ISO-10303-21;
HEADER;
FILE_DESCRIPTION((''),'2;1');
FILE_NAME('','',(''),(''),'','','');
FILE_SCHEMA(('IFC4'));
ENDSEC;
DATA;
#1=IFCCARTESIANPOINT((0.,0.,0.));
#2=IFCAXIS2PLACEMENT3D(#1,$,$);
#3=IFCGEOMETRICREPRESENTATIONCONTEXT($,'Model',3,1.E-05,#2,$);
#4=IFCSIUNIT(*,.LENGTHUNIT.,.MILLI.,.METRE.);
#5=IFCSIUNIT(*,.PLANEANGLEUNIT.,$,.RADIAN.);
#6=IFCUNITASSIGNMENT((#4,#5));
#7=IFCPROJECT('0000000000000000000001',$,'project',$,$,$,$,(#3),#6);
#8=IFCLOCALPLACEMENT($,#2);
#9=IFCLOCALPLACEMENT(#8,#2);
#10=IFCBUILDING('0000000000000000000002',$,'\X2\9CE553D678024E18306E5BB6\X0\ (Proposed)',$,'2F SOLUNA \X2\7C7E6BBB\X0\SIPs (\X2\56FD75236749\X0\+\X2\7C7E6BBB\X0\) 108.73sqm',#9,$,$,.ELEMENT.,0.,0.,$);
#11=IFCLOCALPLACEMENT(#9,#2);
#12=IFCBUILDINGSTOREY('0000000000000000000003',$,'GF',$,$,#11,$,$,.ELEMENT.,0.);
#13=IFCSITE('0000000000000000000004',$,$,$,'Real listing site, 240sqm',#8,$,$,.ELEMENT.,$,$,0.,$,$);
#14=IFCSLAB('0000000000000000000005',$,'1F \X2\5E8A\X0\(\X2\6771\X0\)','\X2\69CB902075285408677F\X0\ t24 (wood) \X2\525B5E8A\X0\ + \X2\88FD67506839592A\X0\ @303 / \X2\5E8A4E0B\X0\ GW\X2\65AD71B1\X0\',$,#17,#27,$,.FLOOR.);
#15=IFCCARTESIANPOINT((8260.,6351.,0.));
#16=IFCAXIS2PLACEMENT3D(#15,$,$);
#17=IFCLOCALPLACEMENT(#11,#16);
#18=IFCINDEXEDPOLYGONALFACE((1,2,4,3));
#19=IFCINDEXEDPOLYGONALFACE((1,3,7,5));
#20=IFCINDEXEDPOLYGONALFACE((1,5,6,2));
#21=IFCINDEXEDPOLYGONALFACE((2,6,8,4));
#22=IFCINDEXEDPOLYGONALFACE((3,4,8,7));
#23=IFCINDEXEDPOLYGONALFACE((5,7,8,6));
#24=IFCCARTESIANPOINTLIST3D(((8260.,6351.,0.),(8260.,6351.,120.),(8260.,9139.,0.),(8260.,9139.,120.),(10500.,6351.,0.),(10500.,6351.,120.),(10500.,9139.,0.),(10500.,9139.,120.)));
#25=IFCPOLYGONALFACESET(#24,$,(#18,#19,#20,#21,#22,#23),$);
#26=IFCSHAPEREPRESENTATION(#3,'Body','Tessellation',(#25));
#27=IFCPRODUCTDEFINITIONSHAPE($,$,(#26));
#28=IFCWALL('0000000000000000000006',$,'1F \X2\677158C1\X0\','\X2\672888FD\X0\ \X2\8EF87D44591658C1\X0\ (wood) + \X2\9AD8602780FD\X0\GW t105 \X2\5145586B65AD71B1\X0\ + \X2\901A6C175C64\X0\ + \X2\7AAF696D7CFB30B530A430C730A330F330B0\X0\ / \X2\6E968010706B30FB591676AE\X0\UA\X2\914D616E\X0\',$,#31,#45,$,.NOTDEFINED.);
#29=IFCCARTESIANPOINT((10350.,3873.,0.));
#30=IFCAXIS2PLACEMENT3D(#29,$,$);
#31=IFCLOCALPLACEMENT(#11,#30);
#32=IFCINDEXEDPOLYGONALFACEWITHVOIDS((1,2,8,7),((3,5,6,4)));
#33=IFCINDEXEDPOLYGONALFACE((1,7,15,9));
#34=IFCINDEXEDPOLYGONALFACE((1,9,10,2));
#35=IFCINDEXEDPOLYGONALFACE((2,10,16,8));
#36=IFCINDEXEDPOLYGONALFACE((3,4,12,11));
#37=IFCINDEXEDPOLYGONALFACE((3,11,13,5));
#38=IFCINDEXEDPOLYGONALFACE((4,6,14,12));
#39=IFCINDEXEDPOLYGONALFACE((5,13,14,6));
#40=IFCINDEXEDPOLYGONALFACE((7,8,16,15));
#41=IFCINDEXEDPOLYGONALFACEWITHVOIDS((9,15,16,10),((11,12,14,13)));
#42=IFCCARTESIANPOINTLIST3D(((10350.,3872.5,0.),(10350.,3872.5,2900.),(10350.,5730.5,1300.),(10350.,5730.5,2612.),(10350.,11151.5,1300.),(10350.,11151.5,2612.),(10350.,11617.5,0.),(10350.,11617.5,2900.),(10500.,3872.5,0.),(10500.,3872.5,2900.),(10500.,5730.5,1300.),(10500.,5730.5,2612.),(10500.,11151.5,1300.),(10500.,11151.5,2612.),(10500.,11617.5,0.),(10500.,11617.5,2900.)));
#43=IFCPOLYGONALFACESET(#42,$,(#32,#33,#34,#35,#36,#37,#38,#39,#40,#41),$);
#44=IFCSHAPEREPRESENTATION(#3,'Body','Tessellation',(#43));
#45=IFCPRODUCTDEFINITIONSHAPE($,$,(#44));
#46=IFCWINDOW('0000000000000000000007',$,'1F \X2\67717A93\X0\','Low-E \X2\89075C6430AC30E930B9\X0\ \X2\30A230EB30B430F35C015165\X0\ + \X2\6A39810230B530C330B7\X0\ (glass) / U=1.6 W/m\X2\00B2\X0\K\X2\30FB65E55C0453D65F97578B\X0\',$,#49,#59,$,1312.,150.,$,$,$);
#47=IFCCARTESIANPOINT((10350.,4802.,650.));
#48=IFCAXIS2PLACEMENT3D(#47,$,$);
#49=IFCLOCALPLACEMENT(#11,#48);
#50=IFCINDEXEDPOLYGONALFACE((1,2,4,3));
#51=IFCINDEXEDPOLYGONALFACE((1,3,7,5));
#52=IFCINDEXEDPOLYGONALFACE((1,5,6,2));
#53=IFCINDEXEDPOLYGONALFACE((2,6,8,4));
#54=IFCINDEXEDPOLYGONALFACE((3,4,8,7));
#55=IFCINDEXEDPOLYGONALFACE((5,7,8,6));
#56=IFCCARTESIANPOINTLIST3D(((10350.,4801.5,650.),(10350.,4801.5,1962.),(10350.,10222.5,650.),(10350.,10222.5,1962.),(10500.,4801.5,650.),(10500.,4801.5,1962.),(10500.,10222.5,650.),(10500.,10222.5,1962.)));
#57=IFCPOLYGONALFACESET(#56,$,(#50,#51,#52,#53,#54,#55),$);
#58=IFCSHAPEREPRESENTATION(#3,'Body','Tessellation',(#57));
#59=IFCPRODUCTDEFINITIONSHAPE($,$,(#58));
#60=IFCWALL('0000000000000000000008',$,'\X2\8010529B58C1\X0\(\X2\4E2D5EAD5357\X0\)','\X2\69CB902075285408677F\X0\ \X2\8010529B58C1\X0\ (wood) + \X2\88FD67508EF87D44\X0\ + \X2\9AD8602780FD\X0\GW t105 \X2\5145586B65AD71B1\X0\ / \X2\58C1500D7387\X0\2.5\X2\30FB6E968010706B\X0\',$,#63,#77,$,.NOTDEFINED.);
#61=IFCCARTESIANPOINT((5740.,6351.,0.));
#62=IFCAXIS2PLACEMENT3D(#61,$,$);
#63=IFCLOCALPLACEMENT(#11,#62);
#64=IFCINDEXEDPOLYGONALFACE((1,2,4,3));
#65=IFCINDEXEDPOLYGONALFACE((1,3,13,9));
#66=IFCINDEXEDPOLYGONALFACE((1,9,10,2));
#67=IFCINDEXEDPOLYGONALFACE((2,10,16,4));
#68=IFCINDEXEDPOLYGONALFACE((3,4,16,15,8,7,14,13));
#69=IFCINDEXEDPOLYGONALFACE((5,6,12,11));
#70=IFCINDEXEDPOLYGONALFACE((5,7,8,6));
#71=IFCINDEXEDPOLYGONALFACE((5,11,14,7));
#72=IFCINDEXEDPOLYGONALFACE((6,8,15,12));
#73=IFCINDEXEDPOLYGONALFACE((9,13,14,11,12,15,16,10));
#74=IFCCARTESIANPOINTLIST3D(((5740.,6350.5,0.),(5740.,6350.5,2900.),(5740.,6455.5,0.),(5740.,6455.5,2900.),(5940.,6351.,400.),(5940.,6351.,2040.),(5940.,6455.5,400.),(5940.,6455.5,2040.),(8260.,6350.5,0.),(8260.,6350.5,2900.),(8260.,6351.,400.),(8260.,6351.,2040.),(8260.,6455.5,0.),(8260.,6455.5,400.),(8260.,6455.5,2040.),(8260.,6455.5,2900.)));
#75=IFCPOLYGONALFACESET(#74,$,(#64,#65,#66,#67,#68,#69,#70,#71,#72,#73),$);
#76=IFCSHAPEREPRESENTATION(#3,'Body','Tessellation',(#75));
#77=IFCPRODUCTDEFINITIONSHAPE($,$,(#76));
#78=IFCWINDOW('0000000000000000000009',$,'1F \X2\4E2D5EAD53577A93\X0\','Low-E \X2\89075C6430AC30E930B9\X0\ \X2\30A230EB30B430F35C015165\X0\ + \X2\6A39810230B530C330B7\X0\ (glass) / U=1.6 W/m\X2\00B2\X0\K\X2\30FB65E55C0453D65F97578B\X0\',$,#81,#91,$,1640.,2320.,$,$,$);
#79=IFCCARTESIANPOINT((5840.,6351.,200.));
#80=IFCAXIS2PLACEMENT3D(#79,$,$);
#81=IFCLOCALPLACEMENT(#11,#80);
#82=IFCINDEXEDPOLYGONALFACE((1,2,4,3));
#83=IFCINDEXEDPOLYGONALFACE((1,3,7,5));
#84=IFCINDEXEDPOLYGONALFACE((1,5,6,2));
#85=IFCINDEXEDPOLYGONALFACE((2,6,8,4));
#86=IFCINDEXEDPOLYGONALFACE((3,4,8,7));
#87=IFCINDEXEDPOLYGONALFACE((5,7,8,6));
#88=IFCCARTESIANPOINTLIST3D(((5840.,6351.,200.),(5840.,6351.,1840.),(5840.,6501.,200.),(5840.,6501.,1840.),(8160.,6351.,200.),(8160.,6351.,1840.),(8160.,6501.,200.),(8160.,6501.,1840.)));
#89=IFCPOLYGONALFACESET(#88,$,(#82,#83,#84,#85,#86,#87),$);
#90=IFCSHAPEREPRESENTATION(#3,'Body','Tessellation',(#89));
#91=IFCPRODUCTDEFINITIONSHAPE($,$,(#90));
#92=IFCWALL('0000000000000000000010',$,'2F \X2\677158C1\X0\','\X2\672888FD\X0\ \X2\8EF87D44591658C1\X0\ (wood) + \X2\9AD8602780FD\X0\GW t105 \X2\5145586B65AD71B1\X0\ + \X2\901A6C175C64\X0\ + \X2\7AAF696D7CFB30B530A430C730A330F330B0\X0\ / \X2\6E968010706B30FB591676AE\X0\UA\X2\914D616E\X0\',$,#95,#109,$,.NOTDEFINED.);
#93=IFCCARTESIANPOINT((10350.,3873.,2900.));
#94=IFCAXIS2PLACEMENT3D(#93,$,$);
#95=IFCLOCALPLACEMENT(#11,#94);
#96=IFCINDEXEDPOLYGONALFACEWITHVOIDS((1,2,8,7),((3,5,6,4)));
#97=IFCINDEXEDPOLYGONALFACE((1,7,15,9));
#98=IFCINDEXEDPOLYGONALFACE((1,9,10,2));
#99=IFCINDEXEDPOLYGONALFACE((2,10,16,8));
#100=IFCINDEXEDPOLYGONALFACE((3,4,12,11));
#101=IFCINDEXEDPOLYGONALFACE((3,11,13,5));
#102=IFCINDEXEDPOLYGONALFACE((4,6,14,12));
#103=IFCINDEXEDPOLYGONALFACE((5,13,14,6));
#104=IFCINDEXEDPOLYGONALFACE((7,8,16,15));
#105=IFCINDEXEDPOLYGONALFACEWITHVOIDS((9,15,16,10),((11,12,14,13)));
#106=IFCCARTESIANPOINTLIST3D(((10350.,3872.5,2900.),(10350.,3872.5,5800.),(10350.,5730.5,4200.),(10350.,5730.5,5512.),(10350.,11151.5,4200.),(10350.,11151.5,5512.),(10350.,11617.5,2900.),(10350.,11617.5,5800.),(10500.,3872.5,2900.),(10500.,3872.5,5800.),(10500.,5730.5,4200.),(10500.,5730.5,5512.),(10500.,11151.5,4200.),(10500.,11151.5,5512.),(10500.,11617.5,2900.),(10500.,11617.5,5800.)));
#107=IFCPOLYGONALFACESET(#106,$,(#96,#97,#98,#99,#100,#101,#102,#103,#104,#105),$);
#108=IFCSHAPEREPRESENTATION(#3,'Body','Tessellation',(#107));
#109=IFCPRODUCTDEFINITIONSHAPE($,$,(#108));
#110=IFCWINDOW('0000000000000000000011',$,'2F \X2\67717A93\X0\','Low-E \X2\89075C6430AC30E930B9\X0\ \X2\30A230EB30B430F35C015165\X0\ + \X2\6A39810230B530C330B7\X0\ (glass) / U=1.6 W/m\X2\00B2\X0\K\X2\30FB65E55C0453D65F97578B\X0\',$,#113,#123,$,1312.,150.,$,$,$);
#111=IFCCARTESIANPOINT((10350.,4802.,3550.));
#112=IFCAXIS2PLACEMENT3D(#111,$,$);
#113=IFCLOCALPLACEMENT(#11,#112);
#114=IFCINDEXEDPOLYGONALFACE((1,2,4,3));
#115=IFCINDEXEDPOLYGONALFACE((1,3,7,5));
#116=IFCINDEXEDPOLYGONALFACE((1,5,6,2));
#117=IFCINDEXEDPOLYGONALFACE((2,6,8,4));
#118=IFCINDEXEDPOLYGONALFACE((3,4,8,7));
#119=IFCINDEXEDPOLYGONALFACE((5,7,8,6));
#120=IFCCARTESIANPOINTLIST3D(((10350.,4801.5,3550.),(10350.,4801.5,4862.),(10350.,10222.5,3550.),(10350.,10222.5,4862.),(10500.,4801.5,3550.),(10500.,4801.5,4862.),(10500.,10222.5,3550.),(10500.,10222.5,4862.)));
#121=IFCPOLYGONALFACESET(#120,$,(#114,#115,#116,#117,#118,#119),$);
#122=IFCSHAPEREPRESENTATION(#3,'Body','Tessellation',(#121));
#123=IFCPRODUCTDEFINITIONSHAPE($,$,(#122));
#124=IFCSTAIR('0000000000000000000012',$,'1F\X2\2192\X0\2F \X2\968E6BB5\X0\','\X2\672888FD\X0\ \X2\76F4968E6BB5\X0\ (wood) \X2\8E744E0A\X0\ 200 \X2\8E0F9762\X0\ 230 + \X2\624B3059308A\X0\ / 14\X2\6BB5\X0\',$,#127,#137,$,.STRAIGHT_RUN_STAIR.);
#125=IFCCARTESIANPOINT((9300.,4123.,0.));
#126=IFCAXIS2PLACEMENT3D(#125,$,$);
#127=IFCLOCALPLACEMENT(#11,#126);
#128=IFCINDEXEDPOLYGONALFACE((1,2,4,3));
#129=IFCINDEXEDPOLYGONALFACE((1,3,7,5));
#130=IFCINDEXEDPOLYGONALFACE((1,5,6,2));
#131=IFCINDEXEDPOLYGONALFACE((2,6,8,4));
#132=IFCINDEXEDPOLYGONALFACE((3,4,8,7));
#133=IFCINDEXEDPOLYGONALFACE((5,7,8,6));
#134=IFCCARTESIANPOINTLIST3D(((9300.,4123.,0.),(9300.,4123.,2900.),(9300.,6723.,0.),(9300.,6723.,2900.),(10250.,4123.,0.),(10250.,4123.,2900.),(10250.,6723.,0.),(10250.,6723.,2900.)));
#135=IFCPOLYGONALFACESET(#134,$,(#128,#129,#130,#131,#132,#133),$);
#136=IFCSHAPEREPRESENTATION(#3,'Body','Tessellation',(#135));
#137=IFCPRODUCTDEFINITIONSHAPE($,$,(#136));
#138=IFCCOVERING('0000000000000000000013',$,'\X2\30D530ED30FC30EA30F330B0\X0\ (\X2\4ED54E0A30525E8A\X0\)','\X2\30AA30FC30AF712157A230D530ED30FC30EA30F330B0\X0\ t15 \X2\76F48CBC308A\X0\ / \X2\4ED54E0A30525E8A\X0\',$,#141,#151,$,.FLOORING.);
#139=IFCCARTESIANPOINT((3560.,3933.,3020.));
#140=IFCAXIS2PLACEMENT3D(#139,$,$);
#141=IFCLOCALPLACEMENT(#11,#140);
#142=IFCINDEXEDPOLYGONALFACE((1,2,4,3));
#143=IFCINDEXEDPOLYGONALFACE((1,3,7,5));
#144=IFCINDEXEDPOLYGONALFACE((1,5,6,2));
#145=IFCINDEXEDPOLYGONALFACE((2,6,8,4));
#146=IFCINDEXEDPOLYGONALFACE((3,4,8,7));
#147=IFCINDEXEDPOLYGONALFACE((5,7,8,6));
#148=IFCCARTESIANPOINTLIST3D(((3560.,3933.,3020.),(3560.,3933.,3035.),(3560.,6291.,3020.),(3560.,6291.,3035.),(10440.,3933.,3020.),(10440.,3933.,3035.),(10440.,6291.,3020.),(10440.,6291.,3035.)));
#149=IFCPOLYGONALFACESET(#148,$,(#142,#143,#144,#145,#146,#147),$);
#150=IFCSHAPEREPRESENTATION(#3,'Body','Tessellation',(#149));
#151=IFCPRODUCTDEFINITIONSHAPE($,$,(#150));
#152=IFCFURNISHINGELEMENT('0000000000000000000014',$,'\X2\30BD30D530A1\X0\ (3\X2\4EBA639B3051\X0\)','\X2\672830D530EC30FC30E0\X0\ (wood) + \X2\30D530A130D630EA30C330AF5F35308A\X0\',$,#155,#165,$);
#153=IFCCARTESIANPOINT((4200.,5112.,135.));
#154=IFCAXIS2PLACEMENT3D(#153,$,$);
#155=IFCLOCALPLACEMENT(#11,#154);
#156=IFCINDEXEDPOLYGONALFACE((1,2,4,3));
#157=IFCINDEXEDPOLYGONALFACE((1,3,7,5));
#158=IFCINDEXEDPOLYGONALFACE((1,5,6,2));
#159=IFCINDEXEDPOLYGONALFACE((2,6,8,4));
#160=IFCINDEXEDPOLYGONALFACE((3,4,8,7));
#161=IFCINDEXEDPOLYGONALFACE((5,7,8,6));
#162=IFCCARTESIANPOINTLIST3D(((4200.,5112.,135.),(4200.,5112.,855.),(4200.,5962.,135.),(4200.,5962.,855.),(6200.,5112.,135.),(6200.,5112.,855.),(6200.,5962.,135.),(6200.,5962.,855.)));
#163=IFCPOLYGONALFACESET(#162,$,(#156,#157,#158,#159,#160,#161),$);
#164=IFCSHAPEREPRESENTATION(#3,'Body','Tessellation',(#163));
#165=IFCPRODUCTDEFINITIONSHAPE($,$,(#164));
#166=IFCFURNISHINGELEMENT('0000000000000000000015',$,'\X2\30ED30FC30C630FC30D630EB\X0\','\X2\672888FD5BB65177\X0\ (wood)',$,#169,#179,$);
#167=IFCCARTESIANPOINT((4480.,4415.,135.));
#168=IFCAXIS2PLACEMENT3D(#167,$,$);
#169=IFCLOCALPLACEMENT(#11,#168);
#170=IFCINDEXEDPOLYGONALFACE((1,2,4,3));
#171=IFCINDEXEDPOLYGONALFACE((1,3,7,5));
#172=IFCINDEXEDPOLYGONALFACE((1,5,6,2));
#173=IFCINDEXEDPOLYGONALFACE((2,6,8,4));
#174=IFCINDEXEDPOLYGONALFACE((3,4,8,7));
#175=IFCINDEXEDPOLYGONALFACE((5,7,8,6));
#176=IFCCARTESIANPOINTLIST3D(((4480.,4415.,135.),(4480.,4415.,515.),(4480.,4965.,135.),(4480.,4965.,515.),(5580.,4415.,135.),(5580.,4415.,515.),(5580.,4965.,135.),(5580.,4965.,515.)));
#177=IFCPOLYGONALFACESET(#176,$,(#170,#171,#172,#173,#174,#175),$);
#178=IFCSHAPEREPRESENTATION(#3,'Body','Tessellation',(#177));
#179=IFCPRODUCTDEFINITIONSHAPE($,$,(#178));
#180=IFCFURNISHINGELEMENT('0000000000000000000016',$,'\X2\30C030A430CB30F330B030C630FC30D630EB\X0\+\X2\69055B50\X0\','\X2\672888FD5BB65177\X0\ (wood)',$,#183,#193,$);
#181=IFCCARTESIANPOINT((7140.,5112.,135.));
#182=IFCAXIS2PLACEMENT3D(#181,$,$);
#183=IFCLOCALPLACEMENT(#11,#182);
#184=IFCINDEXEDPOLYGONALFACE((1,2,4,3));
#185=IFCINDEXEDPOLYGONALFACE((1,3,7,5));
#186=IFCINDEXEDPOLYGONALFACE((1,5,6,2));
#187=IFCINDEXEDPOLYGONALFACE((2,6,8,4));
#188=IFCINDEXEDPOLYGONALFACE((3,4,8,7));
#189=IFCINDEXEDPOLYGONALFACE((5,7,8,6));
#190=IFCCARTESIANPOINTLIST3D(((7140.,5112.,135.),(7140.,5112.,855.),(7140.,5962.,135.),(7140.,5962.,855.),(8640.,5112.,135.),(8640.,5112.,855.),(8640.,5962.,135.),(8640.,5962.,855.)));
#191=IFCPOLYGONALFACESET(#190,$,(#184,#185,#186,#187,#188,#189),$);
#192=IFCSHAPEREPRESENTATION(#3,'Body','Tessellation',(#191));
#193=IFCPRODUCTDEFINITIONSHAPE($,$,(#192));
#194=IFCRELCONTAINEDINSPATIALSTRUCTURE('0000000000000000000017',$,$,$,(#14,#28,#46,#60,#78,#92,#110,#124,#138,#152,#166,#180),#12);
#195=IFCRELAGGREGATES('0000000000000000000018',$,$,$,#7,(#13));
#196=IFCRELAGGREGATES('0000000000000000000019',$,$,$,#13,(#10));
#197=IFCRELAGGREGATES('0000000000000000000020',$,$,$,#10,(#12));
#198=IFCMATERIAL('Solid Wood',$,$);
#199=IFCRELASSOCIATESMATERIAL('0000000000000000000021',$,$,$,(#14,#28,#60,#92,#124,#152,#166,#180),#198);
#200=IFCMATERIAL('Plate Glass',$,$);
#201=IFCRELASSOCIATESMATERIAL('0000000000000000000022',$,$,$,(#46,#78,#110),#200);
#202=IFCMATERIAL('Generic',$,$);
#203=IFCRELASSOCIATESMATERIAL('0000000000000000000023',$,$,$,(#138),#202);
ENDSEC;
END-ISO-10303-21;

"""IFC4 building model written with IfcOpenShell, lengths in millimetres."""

from ifc_helpers import new_model, si_unit, frame, frame_2d, origin, place, context, project, spatial, rectangle, extrude, material, element, fill, save


model = new_model("IFC4")

# Units and contexts
model_context = context("Model", 3, precision=1e-05, world=origin())
ifc_project = project(units=[si_unit("LENGTHUNIT", "METRE", prefix="MILLI"), si_unit("PLANEANGLEUNIT", "RADIAN")], contexts=[model_context])

# Site, building, storey
site_placement = place(None, origin())
site = spatial("IfcSite", under=ifc_project, at=site_placement, ObjectType="Real listing site, 240sqm", CompositionType="ELEMENT", RefElevation=0.0)
building_placement = place(site_placement, origin())
building = spatial("IfcBuilding", under=site, at=building_placement, Name="鳥取砂丘の家 (Proposed)", ObjectType="2F SOLUNA 籾殻SIPs (国産杉+籾殻) 108.73sqm", CompositionType="ELEMENT", ElevationOfRefHeight=0.0, ElevationOfTerrain=0.0)
storey_placement = place(building_placement, origin())
storey = spatial("IfcBuildingStorey", under=building, at=storey_placement, Name="GF", CompositionType="ELEMENT", Elevation=0.0)

# Slab
ifc_material_1 = material(Name="Solid Wood")
slab_placement = place(storey_placement, frame((8260.0, 6351.0, 0.0)))
element("IfcSlab", 1, at=slab_placement, inside=storey, material=ifc_material_1, Name="1F 床(東)", Description="構造用合板 t24 (wood) 剛床 + 製材根太 @303 / 床下 GW断熱", PredefinedType="FLOOR", context=model_context, shape_type="SweptSolid", body=[
    extrude(rectangle(XDim=2240.0, YDim=2788.0, at=frame_2d((1120.0, 1394.0))), frame((8260.0, 6351.0, 0.0)), (0.0, 0.0, 1.0), 120.0),
])

# Walls, openings, windows
wall_1_placement = place(storey_placement, frame((10350.0, 3873.0, 0.0)))
wall_1 = element("IfcWall", 2, at=wall_1_placement, inside=storey, material=ifc_material_1, Name="1F 東壁", Description="木製 軸組外壁 (wood) + 高性能GW t105 充填断熱 + 通気層 + 窯業系サイディング / 準耐火・外皮UA配慮", PredefinedType="NOTDEFINED", context=model_context, shape_type="SweptSolid", body=[
    extrude(rectangle(XDim=150.0, YDim=7745.0, at=frame_2d((75.0, 3872.0))), frame((10350.0, 3873.0, 0.0)), (0.0, 0.0, 1.0), 2900.0),
])
opening_1_placement = place(storey_placement, frame((10350.0, 4802.0, 650.0)))
opening_1 = element("IfcOpeningElement", 3, at=opening_1_placement, cuts=wall_1, PredefinedType="NOTDEFINED", context=model_context, shape_type="SweptSolid", body=[
    extrude(rectangle(XDim=150.0, YDim=5421.0, at=frame_2d((75.0, 2710.0))), frame((10350.0, 4802.0, 650.0)), (0.0, 0.0, 1.0), 1312.0),
])
ifc_material_2 = material(Name="Plate Glass")
window_1_placement = place(storey_placement, frame((10350.0, 4802.0, 650.0)))
window_1 = element("IfcWindow", 4, at=window_1_placement, inside=storey, material=ifc_material_2, Name="1F 東窓", Description="Low-E 複層ガラス アルゴン封入 + 樹脂サッシ (glass) / U=1.6 W/m²K・日射取得型", OverallHeight=1312.0, OverallWidth=150.0, context=model_context, shape_type="SweptSolid", body=[
    extrude(rectangle(XDim=150.0, YDim=5421.0, at=frame_2d((75.0, 2710.0))), frame((10350.0, 4802.0, 650.0)), (0.0, 0.0, 1.0), 1312.0),
])
fill(opening_1, window_1)
wall_2_placement = place(storey_placement, frame((5740.0, 6351.0, 0.0)))
wall_2 = element("IfcWall", 5, at=wall_2_placement, inside=storey, material=ifc_material_1, Name="耐力壁(中庭南)", Description="構造用合板 耐力壁 (wood) + 製材軸組 + 高性能GW t105 充填断熱 / 壁倍率2.5・準耐火", PredefinedType="NOTDEFINED", context=model_context, shape_type="SweptSolid", body=[
    extrude(rectangle(XDim=2520.0, YDim=105.0, at=frame_2d((1260.0, 52.0))), frame((5740.0, 6351.0, 0.0)), (0.0, 0.0, 1.0), 2900.0),
])
opening_2_placement = place(storey_placement, frame((5840.0, 6351.0, 200.0)))
opening_2 = element("IfcOpeningElement", 6, at=opening_2_placement, cuts=wall_2, PredefinedType="NOTDEFINED", context=model_context, shape_type="SweptSolid", body=[
    extrude(rectangle(XDim=2320.0, YDim=150.0, at=frame_2d((1160.0, 75.0))), frame((5840.0, 6351.0, 200.0)), (0.0, 0.0, 1.0), 1640.0),
])
window_2_placement = place(storey_placement, frame((5840.0, 6351.0, 200.0)))
window_2 = element("IfcWindow", 7, at=window_2_placement, inside=storey, material=ifc_material_2, Name="1F 中庭南窓", Description="Low-E 複層ガラス アルゴン封入 + 樹脂サッシ (glass) / U=1.6 W/m²K・日射取得型", OverallHeight=1640.0, OverallWidth=2320.0, context=model_context, shape_type="SweptSolid", body=[
    extrude(rectangle(XDim=2320.0, YDim=150.0, at=frame_2d((1160.0, 75.0))), frame((5840.0, 6351.0, 200.0)), (0.0, 0.0, 1.0), 1640.0),
])
fill(opening_2, window_2)

# Wall, opening, window
wall_3_placement = place(storey_placement, frame((10350.0, 3873.0, 2900.0)))
wall_3 = element("IfcWall", 8, at=wall_3_placement, inside=storey, material=ifc_material_1, Name="2F 東壁", Description="木製 軸組外壁 (wood) + 高性能GW t105 充填断熱 + 通気層 + 窯業系サイディング / 準耐火・外皮UA配慮", PredefinedType="NOTDEFINED", context=model_context, shape_type="SweptSolid", body=[
    extrude(rectangle(XDim=150.0, YDim=7745.0, at=frame_2d((75.0, 3872.0))), frame((10350.0, 3873.0, 2900.0)), (0.0, 0.0, 1.0), 2900.0),
])
opening_3_placement = place(storey_placement, frame((10350.0, 4802.0, 3550.0)))
opening_3 = element("IfcOpeningElement", 9, at=opening_3_placement, cuts=wall_3, PredefinedType="NOTDEFINED", context=model_context, shape_type="SweptSolid", body=[
    extrude(rectangle(XDim=150.0, YDim=5421.0, at=frame_2d((75.0, 2710.0))), frame((10350.0, 4802.0, 3550.0)), (0.0, 0.0, 1.0), 1312.0),
])
window_3_placement = place(storey_placement, frame((10350.0, 4802.0, 3550.0)))
window_3 = element("IfcWindow", 10, at=window_3_placement, inside=storey, material=ifc_material_2, Name="2F 東窓", Description="Low-E 複層ガラス アルゴン封入 + 樹脂サッシ (glass) / U=1.6 W/m²K・日射取得型", OverallHeight=1312.0, OverallWidth=150.0, context=model_context, shape_type="SweptSolid", body=[
    extrude(rectangle(XDim=150.0, YDim=5421.0, at=frame_2d((75.0, 2710.0))), frame((10350.0, 4802.0, 3550.0)), (0.0, 0.0, 1.0), 1312.0),
])
fill(opening_3, window_3)

# Stair
stair_placement = place(storey_placement, frame((9300.0, 4123.0, 0.0)))
element("IfcStair", 11, at=stair_placement, inside=storey, material=ifc_material_1, Name="1F→2F 階段", Description="木製 直階段 (wood) 蹴上 200 踏面 230 + 手すり / 14段", PredefinedType="STRAIGHT_RUN_STAIR", context=model_context, shape_type="SweptSolid", body=[
    extrude(rectangle(XDim=950.0, YDim=2600.0, at=frame_2d((475.0, 1300.0))), frame((9300.0, 4123.0, 0.0)), (0.0, 0.0, 1.0), 2900.0),
])

# Covering
ifc_material_3 = material(Name="Generic")
covering_placement = place(storey_placement, frame((3560.0, 3933.0, 3020.0)))
element("IfcCovering", 12, at=covering_placement, inside=storey, material=ifc_material_3, Name="フローリング (仕上げ床)", Description="オーク無垢フローリング t15 直貼り / 仕上げ床", PredefinedType="FLOORING", context=model_context, shape_type="SweptSolid", body=[
    extrude(rectangle(XDim=6880.0, YDim=2358.0, at=frame_2d((3440.0, 1179.0))), frame((3560.0, 3933.0, 3020.0)), (0.0, 0.0, 1.0), 15.0),
])

# Furnishing elements
furnishing_1_placement = place(storey_placement, frame((4200.0, 5112.0, 135.0)))
element("IfcFurnishingElement", 13, at=furnishing_1_placement, inside=storey, material=ifc_material_1, Name="ソファ (3人掛け)", Description="木フレーム (wood) + ファブリック張り", context=model_context, shape_type="SweptSolid", body=[
    extrude(rectangle(XDim=2000.0, YDim=850.0, at=frame_2d((1000.0, 425.0))), frame((4200.0, 5112.0, 135.0)), (0.0, 0.0, 1.0), 720.0),
])
furnishing_2_placement = place(storey_placement, frame((4480.0, 4415.0, 135.0)))
element("IfcFurnishingElement", 14, at=furnishing_2_placement, inside=storey, material=ifc_material_1, Name="ローテーブル", Description="木製家具 (wood)", context=model_context, shape_type="SweptSolid", body=[
    extrude(rectangle(XDim=1100.0, YDim=550.0, at=frame_2d((550.0, 275.0))), frame((4480.0, 4415.0, 135.0)), (0.0, 0.0, 1.0), 380.0),
])
furnishing_3_placement = place(storey_placement, frame((7140.0, 5112.0, 135.0)))
element("IfcFurnishingElement", 15, at=furnishing_3_placement, inside=storey, material=ifc_material_1, Name="ダイニングテーブル+椅子", Description="木製家具 (wood)", context=model_context, shape_type="SweptSolid", body=[
    extrude(rectangle(XDim=1500.0, YDim=850.0, at=frame_2d((750.0, 425.0))), frame((7140.0, 5112.0, 135.0)), (0.0, 0.0, 1.0), 720.0),
])

save(model, "model.ifc")
